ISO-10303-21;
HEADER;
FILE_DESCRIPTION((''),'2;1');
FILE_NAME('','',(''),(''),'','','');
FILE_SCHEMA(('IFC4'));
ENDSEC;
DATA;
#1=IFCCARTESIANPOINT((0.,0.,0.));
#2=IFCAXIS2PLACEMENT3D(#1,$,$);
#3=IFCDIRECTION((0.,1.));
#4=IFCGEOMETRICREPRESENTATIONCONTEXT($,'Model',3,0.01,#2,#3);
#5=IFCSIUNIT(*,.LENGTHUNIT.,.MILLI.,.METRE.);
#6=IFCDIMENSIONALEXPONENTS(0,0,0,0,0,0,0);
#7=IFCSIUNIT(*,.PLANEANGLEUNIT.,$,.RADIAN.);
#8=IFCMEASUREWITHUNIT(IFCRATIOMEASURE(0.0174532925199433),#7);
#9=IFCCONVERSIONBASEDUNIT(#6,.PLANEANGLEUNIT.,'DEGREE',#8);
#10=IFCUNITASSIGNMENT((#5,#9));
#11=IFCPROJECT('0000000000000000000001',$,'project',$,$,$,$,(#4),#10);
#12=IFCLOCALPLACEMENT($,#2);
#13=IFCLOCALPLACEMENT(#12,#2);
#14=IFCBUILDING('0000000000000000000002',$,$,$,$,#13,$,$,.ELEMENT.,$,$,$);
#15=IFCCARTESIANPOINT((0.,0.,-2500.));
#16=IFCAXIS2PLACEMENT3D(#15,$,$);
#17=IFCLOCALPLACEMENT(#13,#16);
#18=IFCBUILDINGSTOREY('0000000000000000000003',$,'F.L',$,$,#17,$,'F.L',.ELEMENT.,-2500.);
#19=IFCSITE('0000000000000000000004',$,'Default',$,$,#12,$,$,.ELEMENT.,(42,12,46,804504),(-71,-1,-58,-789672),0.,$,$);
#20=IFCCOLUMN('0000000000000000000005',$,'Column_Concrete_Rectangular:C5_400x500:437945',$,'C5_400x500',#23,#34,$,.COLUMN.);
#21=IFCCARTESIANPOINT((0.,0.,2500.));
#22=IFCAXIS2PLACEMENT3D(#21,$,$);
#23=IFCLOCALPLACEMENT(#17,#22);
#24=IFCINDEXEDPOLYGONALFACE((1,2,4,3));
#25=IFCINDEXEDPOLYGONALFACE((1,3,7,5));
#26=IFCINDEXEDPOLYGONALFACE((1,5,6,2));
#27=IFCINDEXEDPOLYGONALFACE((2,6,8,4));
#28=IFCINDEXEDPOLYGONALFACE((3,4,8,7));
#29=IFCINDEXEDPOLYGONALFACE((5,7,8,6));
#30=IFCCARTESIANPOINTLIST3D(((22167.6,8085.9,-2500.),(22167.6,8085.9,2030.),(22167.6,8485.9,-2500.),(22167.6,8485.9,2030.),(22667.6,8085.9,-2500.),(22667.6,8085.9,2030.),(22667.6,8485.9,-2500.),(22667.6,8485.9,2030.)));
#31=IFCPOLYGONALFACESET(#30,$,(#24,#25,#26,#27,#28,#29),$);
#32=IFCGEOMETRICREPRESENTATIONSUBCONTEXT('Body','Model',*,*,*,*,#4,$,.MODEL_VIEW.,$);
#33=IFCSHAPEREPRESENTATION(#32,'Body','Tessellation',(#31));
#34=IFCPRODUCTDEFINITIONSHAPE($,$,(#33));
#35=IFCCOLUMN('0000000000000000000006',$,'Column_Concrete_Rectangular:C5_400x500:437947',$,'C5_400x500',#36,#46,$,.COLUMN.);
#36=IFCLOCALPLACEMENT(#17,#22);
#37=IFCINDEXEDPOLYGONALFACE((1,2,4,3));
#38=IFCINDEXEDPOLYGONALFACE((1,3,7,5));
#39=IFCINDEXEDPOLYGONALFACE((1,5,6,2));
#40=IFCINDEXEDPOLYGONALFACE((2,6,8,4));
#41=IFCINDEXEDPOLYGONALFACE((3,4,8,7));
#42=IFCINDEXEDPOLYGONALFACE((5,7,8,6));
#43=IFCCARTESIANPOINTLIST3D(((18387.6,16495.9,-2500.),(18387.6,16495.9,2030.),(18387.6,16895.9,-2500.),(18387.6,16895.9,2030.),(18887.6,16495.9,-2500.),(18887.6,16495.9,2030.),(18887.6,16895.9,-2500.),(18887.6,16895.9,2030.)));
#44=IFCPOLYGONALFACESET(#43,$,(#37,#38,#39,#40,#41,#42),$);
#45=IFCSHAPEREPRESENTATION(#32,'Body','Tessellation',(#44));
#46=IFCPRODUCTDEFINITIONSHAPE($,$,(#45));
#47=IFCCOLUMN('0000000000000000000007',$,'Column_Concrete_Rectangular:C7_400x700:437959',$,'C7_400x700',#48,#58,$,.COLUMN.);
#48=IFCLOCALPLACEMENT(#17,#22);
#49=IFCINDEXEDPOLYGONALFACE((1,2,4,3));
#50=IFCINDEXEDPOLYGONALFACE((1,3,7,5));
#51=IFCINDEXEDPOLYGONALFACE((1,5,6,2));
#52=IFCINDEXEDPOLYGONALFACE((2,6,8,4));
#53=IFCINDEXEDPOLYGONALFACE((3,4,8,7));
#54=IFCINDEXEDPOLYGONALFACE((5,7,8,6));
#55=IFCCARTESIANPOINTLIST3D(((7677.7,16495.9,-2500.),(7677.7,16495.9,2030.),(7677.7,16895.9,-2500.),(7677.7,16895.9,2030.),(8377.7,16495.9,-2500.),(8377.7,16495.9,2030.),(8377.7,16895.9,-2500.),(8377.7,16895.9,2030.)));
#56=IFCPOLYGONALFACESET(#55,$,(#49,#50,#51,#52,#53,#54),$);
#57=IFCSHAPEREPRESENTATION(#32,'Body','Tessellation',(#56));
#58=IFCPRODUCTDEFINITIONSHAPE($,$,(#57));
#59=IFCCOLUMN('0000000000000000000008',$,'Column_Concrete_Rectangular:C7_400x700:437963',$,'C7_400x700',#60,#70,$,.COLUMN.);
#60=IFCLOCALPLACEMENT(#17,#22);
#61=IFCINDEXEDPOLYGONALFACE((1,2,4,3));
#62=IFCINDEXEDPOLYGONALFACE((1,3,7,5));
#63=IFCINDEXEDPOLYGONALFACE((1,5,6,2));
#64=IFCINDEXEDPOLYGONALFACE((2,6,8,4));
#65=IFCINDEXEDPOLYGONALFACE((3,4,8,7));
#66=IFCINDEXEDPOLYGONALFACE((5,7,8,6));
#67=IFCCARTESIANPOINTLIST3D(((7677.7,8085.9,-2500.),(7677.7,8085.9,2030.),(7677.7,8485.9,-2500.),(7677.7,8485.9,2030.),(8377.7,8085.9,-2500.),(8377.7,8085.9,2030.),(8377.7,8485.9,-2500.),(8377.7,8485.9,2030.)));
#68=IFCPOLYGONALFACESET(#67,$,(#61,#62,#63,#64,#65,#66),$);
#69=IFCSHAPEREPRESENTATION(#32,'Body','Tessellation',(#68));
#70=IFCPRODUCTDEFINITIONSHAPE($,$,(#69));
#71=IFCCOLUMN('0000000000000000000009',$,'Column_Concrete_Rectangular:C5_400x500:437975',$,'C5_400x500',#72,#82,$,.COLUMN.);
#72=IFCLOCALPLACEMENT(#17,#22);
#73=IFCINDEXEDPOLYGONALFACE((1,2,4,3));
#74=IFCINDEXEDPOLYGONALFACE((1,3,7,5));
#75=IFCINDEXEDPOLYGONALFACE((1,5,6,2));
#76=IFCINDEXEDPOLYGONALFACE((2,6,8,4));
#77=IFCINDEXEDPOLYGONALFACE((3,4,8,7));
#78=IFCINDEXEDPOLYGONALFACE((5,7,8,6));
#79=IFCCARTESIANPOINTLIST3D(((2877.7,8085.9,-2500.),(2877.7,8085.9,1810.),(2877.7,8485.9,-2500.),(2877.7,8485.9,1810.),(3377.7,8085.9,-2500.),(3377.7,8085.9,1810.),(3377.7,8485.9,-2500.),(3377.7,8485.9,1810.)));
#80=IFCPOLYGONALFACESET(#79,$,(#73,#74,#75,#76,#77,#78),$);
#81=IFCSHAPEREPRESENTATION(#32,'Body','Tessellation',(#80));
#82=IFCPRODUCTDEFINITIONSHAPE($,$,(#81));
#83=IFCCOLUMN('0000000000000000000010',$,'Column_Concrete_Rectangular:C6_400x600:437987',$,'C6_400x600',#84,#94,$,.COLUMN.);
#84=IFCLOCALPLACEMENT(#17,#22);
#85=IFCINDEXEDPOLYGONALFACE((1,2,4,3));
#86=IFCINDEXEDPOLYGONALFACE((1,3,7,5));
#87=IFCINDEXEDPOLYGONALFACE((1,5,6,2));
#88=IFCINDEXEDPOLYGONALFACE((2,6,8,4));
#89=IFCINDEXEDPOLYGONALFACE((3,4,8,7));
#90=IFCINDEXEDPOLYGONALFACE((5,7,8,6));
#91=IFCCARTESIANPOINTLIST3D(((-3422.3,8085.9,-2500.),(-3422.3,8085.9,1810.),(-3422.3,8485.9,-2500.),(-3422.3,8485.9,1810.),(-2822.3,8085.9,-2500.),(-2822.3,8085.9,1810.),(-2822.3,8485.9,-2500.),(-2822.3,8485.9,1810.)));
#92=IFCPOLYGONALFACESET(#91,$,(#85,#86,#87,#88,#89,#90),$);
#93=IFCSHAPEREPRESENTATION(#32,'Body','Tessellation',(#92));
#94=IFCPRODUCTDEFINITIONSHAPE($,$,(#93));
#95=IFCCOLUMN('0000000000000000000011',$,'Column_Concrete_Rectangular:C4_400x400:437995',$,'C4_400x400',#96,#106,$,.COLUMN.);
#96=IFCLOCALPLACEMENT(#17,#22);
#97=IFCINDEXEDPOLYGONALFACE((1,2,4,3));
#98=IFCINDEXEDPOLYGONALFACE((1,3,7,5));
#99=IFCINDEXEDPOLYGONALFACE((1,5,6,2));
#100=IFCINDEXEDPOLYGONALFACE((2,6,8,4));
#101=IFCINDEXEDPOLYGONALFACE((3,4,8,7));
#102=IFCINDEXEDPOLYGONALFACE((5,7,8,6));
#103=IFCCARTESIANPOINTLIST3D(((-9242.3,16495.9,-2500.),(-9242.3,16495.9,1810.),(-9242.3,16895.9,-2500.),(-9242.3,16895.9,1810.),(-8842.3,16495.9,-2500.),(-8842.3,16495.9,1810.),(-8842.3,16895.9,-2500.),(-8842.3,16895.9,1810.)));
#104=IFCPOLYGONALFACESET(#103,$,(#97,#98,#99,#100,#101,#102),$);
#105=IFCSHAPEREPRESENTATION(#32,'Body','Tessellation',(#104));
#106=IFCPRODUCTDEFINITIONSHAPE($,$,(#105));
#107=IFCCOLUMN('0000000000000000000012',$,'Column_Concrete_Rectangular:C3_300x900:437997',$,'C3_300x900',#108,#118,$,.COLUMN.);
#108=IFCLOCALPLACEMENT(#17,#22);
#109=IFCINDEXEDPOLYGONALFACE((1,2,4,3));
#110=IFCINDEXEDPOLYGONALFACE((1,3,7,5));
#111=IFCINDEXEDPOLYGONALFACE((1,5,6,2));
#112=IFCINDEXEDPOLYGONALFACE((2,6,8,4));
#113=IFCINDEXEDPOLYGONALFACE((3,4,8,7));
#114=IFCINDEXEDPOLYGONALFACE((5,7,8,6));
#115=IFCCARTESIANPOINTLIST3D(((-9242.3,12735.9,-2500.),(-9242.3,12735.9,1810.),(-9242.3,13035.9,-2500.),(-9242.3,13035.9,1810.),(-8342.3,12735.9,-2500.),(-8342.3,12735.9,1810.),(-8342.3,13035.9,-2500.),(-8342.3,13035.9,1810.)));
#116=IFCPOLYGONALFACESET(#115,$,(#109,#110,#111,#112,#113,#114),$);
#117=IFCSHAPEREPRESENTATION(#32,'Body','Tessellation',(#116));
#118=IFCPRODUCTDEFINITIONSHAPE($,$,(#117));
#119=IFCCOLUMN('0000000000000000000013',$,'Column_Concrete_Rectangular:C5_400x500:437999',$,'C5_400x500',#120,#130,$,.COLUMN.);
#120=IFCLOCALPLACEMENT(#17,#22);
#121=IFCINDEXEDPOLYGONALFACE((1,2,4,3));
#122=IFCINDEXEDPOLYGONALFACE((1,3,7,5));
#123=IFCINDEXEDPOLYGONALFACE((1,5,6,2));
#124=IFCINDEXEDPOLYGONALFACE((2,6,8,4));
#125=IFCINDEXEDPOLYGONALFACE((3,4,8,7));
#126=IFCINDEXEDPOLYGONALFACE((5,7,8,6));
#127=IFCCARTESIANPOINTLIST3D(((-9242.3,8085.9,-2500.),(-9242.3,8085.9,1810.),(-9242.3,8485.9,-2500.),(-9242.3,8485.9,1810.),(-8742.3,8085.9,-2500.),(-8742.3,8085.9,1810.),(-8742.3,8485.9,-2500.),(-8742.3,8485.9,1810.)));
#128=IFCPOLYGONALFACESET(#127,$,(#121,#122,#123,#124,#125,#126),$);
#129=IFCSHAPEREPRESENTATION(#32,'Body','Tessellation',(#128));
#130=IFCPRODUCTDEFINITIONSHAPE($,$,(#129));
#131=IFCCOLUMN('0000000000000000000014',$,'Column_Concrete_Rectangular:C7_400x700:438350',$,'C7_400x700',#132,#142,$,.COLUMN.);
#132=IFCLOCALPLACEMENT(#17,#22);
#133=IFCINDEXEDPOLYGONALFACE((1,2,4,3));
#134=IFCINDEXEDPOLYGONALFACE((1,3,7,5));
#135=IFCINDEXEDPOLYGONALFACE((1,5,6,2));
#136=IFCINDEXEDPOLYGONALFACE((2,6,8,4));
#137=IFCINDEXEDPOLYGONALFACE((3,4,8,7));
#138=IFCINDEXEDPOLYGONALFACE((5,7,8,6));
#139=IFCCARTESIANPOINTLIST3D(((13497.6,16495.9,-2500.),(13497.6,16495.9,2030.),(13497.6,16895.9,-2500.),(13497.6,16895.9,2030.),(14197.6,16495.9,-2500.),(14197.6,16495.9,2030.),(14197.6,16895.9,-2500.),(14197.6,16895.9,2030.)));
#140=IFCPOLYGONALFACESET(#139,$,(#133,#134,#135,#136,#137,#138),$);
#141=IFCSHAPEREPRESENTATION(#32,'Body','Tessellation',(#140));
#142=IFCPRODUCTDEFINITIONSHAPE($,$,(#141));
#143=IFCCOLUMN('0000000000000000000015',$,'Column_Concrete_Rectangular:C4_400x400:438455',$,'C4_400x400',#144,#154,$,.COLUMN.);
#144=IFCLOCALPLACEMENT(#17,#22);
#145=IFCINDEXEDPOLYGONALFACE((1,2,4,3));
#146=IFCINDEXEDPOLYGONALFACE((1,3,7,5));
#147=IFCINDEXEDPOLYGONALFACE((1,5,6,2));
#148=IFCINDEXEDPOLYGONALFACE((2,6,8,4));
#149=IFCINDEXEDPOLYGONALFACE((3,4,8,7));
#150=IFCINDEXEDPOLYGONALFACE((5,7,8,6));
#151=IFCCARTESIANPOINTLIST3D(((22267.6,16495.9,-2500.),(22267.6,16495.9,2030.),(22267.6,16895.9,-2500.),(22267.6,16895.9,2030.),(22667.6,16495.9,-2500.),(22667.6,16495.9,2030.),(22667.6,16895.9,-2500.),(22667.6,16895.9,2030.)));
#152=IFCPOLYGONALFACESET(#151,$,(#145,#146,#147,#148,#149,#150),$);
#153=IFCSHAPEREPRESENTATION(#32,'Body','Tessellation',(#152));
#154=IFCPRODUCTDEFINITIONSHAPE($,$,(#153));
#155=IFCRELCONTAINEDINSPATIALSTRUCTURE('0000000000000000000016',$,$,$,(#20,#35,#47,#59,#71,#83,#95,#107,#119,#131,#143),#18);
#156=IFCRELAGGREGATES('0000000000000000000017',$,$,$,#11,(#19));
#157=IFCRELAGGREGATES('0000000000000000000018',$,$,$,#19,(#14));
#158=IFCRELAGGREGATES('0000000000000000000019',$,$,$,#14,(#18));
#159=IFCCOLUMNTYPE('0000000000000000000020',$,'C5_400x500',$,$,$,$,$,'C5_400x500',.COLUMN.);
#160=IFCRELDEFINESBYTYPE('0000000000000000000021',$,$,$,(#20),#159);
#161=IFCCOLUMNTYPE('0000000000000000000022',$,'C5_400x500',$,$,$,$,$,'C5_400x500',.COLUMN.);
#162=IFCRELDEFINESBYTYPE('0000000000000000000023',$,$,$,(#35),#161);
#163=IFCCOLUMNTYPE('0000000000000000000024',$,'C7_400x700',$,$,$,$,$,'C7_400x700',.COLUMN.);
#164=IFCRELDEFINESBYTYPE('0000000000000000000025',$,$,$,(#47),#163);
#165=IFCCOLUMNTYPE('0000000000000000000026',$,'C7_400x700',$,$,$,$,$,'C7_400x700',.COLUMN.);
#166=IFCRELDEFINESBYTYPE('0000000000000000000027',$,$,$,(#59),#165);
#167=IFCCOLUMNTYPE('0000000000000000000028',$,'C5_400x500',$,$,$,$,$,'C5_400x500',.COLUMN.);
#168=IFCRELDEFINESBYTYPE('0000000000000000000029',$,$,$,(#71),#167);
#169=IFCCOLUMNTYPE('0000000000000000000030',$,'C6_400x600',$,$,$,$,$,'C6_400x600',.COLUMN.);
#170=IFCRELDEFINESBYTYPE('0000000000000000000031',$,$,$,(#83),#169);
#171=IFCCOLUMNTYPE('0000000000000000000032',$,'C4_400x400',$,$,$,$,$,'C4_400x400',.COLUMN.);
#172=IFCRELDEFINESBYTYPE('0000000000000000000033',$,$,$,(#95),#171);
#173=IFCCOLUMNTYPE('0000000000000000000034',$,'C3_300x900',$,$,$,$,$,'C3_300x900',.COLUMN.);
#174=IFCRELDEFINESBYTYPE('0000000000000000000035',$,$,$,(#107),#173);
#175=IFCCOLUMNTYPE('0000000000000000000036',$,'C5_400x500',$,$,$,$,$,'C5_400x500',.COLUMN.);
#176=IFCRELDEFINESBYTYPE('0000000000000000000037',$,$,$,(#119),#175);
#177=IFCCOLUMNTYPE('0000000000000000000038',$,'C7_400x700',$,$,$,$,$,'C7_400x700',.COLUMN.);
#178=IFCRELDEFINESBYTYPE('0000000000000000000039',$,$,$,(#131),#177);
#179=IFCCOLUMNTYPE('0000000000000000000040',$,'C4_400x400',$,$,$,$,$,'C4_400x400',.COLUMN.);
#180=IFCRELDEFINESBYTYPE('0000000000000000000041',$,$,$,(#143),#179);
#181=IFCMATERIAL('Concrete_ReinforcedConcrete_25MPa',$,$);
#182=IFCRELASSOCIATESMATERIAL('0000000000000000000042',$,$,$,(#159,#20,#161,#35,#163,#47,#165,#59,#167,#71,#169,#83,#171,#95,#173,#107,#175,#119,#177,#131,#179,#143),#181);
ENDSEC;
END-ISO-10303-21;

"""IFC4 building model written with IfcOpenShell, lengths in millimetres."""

from ifc_helpers import new_model, entity, si_unit, converted_unit, direction, frame, frame_2d, origin, origin_2d_with_axis, place, context, subcontext, project, spatial, rectangle, extrude, source, transform, mapped, material, type_object, type_shapes, element, save


model = new_model("IFC4")

# Units and contexts
model_context = context("Model", 3, precision=0.01, world=origin(), true_north=direction((0.0, 1.0)))
body_context = subcontext(model_context, "Body", "Model", "MODEL_VIEW")
ifc_project = project(units=[si_unit("LENGTHUNIT", "METRE", prefix="MILLI"), converted_unit("PLANEANGLEUNIT", "DEGREE", entity("IfcRatioMeasure", 0.0174532925199433), si_unit("PLANEANGLEUNIT", "RADIAN"), dimensions=[0, 0, 0, 0, 0, 0, 0])], contexts=[model_context])

# Site, building, storey
site_placement = place(None, origin())
site = spatial("IfcSite", under=ifc_project, at=site_placement, Name="Default", CompositionType="ELEMENT", RefLatitude=(42, 12, 46, 804504), RefLongitude=(-71, -1, -58, -789672), RefElevation=0.0)
building_placement = place(site_placement, origin())
building = spatial("IfcBuilding", under=site, at=building_placement, CompositionType="ELEMENT")
storey_placement = place(building_placement, frame((0.0, 0.0, -2500.0)))
storey = spatial("IfcBuildingStorey", under=building, at=storey_placement, Name="F.L", LongName="F.L", CompositionType="ELEMENT", Elevation=-2500.0)

# Columns
ifc_material_1 = material(Name="Concrete_ReinforcedConcrete_25MPa")
column_type_1 = type_object("IfcColumnType", Name="C5_400x500", ElementType="C5_400x500", PredefinedType="COLUMN", material=ifc_material_1)
shared_shape_1 = source(origin(), body_context, "Body", "SweptSolid", [
    extrude(rectangle(XDim=400.0, YDim=500.0, at=frame_2d((0.0, 0.0), x_axis=(1.0, 0.0))), frame((22417.6, 8285.9, -2500.0), z_axis=(0.0, 0.0, 1.0), x_axis=(0.0, -1.0, 0.0)), (0.0, 0.0, 1.0), 4530.0),
])
type_shapes(column_type_1, [shared_shape_1])
column_1_placement = place(storey_placement, frame((0.0, 0.0, 2500.0)))
element("IfcColumn", 1, at=column_1_placement, inside=storey, type_object=column_type_1, material=ifc_material_1, Name="Column_Concrete_Rectangular:C5_400x500:437945", ObjectType="C5_400x500", PredefinedType="COLUMN", context=body_context, shape_type="MappedRepresentation", body=[
    mapped(shared_shape_1, transform((0.0, 0.0, 0.0), scale=1.0)),
])
column_type_2 = type_object("IfcColumnType", Name="C5_400x500", ElementType="C5_400x500", PredefinedType="COLUMN", material=ifc_material_1)
shared_shape_2 = source(origin(), body_context, "Body", "SweptSolid", [
    extrude(rectangle(XDim=400.0, YDim=500.0, at=frame_2d((0.0, 0.0), x_axis=(1.0, 0.0))), frame((18637.6, 16695.9, -2500.0), z_axis=(0.0, 0.0, 1.0), x_axis=(0.0, -1.0, 0.0)), (0.0, 0.0, 1.0), 4530.0),
])
type_shapes(column_type_2, [shared_shape_2])
column_2_placement = place(storey_placement, frame((0.0, 0.0, 2500.0)))
element("IfcColumn", 2, at=column_2_placement, inside=storey, type_object=column_type_2, material=ifc_material_1, Name="Column_Concrete_Rectangular:C5_400x500:437947", ObjectType="C5_400x500", PredefinedType="COLUMN", context=body_context, shape_type="MappedRepresentation", body=[
    mapped(shared_shape_2, transform((0.0, 0.0, 0.0), scale=1.0)),
])
column_type_3 = type_object("IfcColumnType", Name="C7_400x700", ElementType="C7_400x700", PredefinedType="COLUMN", material=ifc_material_1)
shared_shape_3 = source(origin(), body_context, "Body", "SweptSolid", [
    extrude(rectangle(XDim=400.0, YDim=700.0, at=frame_2d((0.0, 0.0), x_axis=(1.0, 0.0))), frame((8027.7, 16695.9, -2500.0), z_axis=(0.0, 0.0, 1.0), x_axis=(0.0, -1.0, 0.0)), (0.0, 0.0, 1.0), 4530.0),
])
type_shapes(column_type_3, [shared_shape_3])
column_3_placement = place(storey_placement, frame((0.0, 0.0, 2500.0)))
element("IfcColumn", 3, at=column_3_placement, inside=storey, type_object=column_type_3, material=ifc_material_1, Name="Column_Concrete_Rectangular:C7_400x700:437959", ObjectType="C7_400x700", PredefinedType="COLUMN", context=body_context, shape_type="MappedRepresentation", body=[
    mapped(shared_shape_3, transform((0.0, 0.0, 0.0), scale=1.0)),
])
column_type_4 = type_object("IfcColumnType", Name="C7_400x700", ElementType="C7_400x700", PredefinedType="COLUMN", material=ifc_material_1)
shared_shape_4 = source(origin(), body_context, "Body", "SweptSolid", [
    extrude(rectangle(XDim=400.0, YDim=700.0, at=origin_2d_with_axis()), frame((8027.7, 8285.9, -2500.0), z_axis=(0.0, 0.0, 1.0), x_axis=(0.0, -1.0, 0.0)), (0.0, 0.0, 1.0), 4530.0),
])
type_shapes(column_type_4, [shared_shape_4])
column_4_placement = place(storey_placement, frame((0.0, 0.0, 2500.0)))
element("IfcColumn", 4, at=column_4_placement, inside=storey, type_object=column_type_4, material=ifc_material_1, Name="Column_Concrete_Rectangular:C7_400x700:437963", ObjectType="C7_400x700", PredefinedType="COLUMN", context=body_context, shape_type="MappedRepresentation", body=[
    mapped(shared_shape_4, transform((0.0, 0.0, 0.0), scale=1.0)),
])
column_type_5 = type_object("IfcColumnType", Name="C5_400x500", ElementType="C5_400x500", PredefinedType="COLUMN", material=ifc_material_1)
shared_shape_5 = source(origin(), body_context, "Body", "SweptSolid", [
    extrude(rectangle(XDim=400.0, YDim=500.0, at=origin_2d_with_axis()), frame((3127.7, 8285.9, -2500.0), z_axis=(0.0, 0.0, 1.0), x_axis=(0.0, -1.0, 0.0)), (0.0, 0.0, 1.0), 4310.0),
])
type_shapes(column_type_5, [shared_shape_5])
column_5_placement = place(storey_placement, frame((0.0, 0.0, 2500.0)))
element("IfcColumn", 5, at=column_5_placement, inside=storey, type_object=column_type_5, material=ifc_material_1, Name="Column_Concrete_Rectangular:C5_400x500:437975", ObjectType="C5_400x500", PredefinedType="COLUMN", context=body_context, shape_type="MappedRepresentation", body=[
    mapped(shared_shape_5, transform((0.0, 0.0, 0.0), scale=1.0)),
])
column_type_6 = type_object("IfcColumnType", Name="C6_400x600", ElementType="C6_400x600", PredefinedType="COLUMN", material=ifc_material_1)
shared_shape_6 = source(origin(), body_context, "Body", "SweptSolid", [
    extrude(rectangle(XDim=400.0, YDim=600.0, at=origin_2d_with_axis()), frame((-3122.3, 8285.9, -2500.0), z_axis=(0.0, 0.0, 1.0), x_axis=(0.0, -1.0, 0.0)), (0.0, 0.0, 1.0), 4310.0),
])
type_shapes(column_type_6, [shared_shape_6])
column_6_placement = place(storey_placement, frame((0.0, 0.0, 2500.0)))
element("IfcColumn", 6, at=column_6_placement, inside=storey, type_object=column_type_6, material=ifc_material_1, Name="Column_Concrete_Rectangular:C6_400x600:437987", ObjectType="C6_400x600", PredefinedType="COLUMN", context=body_context, shape_type="MappedRepresentation", body=[
    mapped(shared_shape_6, transform((0.0, 0.0, 0.0), scale=1.0)),
])
column_type_7 = type_object("IfcColumnType", Name="C4_400x400", ElementType="C4_400x400", PredefinedType="COLUMN", material=ifc_material_1)
shared_shape_7 = source(origin(), body_context, "Body", "SweptSolid", [
    extrude(rectangle(XDim=400.0, YDim=400.0, at=origin_2d_with_axis()), frame((-9042.3, 16695.9, -2500.0), z_axis=(0.0, 0.0, 1.0), x_axis=(0.0, -1.0, 0.0)), (0.0, 0.0, 1.0), 4310.0),
])
type_shapes(column_type_7, [shared_shape_7])
column_7_placement = place(storey_placement, frame((0.0, 0.0, 2500.0)))
element("IfcColumn", 7, at=column_7_placement, inside=storey, type_object=column_type_7, material=ifc_material_1, Name="Column_Concrete_Rectangular:C4_400x400:437995", ObjectType="C4_400x400", PredefinedType="COLUMN", context=body_context, shape_type="MappedRepresentation", body=[
    mapped(shared_shape_7, transform((0.0, 0.0, 0.0), scale=1.0)),
])
column_type_8 = type_object("IfcColumnType", Name="C3_300x900", ElementType="C3_300x900", PredefinedType="COLUMN", material=ifc_material_1)
shared_shape_8 = source(origin(), body_context, "Body", "SweptSolid", [
    extrude(rectangle(XDim=300.0, YDim=900.0, at=frame_2d((0.0, 0.0), x_axis=(1.0, 0.0))), frame((-8792.3, 12885.9, -2500.0), z_axis=(0.0, 0.0, 1.0), x_axis=(0.0, -1.0, 0.0)), (0.0, 0.0, 1.0), 4310.0),
])
type_shapes(column_type_8, [shared_shape_8])
column_8_placement = place(storey_placement, frame((0.0, 0.0, 2500.0)))
element("IfcColumn", 8, at=column_8_placement, inside=storey, type_object=column_type_8, material=ifc_material_1, Name="Column_Concrete_Rectangular:C3_300x900:437997", ObjectType="C3_300x900", PredefinedType="COLUMN", context=body_context, shape_type="MappedRepresentation", body=[
    mapped(shared_shape_8, transform((0.0, 0.0, 0.0), scale=1.0)),
])
column_type_9 = type_object("IfcColumnType", Name="C5_400x500", ElementType="C5_400x500", PredefinedType="COLUMN", material=ifc_material_1)
shared_shape_9 = source(origin(), body_context, "Body", "SweptSolid", [
    extrude(rectangle(XDim=400.0, YDim=500.0, at=frame_2d((0.0, 0.0), x_axis=(1.0, 0.0))), frame((-8992.3, 8285.9, -2500.0), z_axis=(0.0, 0.0, 1.0), x_axis=(0.0, -1.0, 0.0)), (0.0, 0.0, 1.0), 4310.0),
])
type_shapes(column_type_9, [shared_shape_9])
column_9_placement = place(storey_placement, frame((0.0, 0.0, 2500.0)))
element("IfcColumn", 9, at=column_9_placement, inside=storey, type_object=column_type_9, material=ifc_material_1, Name="Column_Concrete_Rectangular:C5_400x500:437999", ObjectType="C5_400x500", PredefinedType="COLUMN", context=body_context, shape_type="MappedRepresentation", body=[
    mapped(shared_shape_9, transform((0.0, 0.0, 0.0), scale=1.0)),
])
column_type_10 = type_object("IfcColumnType", Name="C7_400x700", ElementType="C7_400x700", PredefinedType="COLUMN", material=ifc_material_1)
shared_shape_10 = source(origin(), body_context, "Body", "SweptSolid", [
    extrude(rectangle(XDim=400.0, YDim=700.0, at=frame_2d((0.0, 0.0), x_axis=(1.0, 0.0))), frame((13847.6, 16695.9, -2500.0), z_axis=(0.0, 0.0, 1.0), x_axis=(0.0, -1.0, 0.0)), (0.0, 0.0, 1.0), 4530.0),
])
type_shapes(column_type_10, [shared_shape_10])
column_10_placement = place(storey_placement, frame((0.0, 0.0, 2500.0)))
element("IfcColumn", 10, at=column_10_placement, inside=storey, type_object=column_type_10, material=ifc_material_1, Name="Column_Concrete_Rectangular:C7_400x700:438350", ObjectType="C7_400x700", PredefinedType="COLUMN", context=body_context, shape_type="MappedRepresentation", body=[
    mapped(shared_shape_10, transform((0.0, 0.0, 0.0), scale=1.0)),
])
column_type_11 = type_object("IfcColumnType", Name="C4_400x400", ElementType="C4_400x400", PredefinedType="COLUMN", material=ifc_material_1)
shared_shape_11 = source(origin(), body_context, "Body", "SweptSolid", [
    extrude(rectangle(XDim=400.0, YDim=400.0, at=frame_2d((0.0, 0.0), x_axis=(1.0, 0.0))), frame((22467.6, 16695.9, -2500.0), z_axis=(0.0, 0.0, 1.0), x_axis=(0.0, -1.0, 0.0)), (0.0, 0.0, 1.0), 4530.0),
])
type_shapes(column_type_11, [shared_shape_11])
column_11_placement = place(storey_placement, frame((0.0, 0.0, 2500.0)))
element("IfcColumn", 11, at=column_11_placement, inside=storey, type_object=column_type_11, material=ifc_material_1, Name="Column_Concrete_Rectangular:C4_400x400:438455", ObjectType="C4_400x400", PredefinedType="COLUMN", context=body_context, shape_type="MappedRepresentation", body=[
    mapped(shared_shape_11, transform((0.0, 0.0, 0.0), scale=1.0)),
])

save(model, "model.ifc")
